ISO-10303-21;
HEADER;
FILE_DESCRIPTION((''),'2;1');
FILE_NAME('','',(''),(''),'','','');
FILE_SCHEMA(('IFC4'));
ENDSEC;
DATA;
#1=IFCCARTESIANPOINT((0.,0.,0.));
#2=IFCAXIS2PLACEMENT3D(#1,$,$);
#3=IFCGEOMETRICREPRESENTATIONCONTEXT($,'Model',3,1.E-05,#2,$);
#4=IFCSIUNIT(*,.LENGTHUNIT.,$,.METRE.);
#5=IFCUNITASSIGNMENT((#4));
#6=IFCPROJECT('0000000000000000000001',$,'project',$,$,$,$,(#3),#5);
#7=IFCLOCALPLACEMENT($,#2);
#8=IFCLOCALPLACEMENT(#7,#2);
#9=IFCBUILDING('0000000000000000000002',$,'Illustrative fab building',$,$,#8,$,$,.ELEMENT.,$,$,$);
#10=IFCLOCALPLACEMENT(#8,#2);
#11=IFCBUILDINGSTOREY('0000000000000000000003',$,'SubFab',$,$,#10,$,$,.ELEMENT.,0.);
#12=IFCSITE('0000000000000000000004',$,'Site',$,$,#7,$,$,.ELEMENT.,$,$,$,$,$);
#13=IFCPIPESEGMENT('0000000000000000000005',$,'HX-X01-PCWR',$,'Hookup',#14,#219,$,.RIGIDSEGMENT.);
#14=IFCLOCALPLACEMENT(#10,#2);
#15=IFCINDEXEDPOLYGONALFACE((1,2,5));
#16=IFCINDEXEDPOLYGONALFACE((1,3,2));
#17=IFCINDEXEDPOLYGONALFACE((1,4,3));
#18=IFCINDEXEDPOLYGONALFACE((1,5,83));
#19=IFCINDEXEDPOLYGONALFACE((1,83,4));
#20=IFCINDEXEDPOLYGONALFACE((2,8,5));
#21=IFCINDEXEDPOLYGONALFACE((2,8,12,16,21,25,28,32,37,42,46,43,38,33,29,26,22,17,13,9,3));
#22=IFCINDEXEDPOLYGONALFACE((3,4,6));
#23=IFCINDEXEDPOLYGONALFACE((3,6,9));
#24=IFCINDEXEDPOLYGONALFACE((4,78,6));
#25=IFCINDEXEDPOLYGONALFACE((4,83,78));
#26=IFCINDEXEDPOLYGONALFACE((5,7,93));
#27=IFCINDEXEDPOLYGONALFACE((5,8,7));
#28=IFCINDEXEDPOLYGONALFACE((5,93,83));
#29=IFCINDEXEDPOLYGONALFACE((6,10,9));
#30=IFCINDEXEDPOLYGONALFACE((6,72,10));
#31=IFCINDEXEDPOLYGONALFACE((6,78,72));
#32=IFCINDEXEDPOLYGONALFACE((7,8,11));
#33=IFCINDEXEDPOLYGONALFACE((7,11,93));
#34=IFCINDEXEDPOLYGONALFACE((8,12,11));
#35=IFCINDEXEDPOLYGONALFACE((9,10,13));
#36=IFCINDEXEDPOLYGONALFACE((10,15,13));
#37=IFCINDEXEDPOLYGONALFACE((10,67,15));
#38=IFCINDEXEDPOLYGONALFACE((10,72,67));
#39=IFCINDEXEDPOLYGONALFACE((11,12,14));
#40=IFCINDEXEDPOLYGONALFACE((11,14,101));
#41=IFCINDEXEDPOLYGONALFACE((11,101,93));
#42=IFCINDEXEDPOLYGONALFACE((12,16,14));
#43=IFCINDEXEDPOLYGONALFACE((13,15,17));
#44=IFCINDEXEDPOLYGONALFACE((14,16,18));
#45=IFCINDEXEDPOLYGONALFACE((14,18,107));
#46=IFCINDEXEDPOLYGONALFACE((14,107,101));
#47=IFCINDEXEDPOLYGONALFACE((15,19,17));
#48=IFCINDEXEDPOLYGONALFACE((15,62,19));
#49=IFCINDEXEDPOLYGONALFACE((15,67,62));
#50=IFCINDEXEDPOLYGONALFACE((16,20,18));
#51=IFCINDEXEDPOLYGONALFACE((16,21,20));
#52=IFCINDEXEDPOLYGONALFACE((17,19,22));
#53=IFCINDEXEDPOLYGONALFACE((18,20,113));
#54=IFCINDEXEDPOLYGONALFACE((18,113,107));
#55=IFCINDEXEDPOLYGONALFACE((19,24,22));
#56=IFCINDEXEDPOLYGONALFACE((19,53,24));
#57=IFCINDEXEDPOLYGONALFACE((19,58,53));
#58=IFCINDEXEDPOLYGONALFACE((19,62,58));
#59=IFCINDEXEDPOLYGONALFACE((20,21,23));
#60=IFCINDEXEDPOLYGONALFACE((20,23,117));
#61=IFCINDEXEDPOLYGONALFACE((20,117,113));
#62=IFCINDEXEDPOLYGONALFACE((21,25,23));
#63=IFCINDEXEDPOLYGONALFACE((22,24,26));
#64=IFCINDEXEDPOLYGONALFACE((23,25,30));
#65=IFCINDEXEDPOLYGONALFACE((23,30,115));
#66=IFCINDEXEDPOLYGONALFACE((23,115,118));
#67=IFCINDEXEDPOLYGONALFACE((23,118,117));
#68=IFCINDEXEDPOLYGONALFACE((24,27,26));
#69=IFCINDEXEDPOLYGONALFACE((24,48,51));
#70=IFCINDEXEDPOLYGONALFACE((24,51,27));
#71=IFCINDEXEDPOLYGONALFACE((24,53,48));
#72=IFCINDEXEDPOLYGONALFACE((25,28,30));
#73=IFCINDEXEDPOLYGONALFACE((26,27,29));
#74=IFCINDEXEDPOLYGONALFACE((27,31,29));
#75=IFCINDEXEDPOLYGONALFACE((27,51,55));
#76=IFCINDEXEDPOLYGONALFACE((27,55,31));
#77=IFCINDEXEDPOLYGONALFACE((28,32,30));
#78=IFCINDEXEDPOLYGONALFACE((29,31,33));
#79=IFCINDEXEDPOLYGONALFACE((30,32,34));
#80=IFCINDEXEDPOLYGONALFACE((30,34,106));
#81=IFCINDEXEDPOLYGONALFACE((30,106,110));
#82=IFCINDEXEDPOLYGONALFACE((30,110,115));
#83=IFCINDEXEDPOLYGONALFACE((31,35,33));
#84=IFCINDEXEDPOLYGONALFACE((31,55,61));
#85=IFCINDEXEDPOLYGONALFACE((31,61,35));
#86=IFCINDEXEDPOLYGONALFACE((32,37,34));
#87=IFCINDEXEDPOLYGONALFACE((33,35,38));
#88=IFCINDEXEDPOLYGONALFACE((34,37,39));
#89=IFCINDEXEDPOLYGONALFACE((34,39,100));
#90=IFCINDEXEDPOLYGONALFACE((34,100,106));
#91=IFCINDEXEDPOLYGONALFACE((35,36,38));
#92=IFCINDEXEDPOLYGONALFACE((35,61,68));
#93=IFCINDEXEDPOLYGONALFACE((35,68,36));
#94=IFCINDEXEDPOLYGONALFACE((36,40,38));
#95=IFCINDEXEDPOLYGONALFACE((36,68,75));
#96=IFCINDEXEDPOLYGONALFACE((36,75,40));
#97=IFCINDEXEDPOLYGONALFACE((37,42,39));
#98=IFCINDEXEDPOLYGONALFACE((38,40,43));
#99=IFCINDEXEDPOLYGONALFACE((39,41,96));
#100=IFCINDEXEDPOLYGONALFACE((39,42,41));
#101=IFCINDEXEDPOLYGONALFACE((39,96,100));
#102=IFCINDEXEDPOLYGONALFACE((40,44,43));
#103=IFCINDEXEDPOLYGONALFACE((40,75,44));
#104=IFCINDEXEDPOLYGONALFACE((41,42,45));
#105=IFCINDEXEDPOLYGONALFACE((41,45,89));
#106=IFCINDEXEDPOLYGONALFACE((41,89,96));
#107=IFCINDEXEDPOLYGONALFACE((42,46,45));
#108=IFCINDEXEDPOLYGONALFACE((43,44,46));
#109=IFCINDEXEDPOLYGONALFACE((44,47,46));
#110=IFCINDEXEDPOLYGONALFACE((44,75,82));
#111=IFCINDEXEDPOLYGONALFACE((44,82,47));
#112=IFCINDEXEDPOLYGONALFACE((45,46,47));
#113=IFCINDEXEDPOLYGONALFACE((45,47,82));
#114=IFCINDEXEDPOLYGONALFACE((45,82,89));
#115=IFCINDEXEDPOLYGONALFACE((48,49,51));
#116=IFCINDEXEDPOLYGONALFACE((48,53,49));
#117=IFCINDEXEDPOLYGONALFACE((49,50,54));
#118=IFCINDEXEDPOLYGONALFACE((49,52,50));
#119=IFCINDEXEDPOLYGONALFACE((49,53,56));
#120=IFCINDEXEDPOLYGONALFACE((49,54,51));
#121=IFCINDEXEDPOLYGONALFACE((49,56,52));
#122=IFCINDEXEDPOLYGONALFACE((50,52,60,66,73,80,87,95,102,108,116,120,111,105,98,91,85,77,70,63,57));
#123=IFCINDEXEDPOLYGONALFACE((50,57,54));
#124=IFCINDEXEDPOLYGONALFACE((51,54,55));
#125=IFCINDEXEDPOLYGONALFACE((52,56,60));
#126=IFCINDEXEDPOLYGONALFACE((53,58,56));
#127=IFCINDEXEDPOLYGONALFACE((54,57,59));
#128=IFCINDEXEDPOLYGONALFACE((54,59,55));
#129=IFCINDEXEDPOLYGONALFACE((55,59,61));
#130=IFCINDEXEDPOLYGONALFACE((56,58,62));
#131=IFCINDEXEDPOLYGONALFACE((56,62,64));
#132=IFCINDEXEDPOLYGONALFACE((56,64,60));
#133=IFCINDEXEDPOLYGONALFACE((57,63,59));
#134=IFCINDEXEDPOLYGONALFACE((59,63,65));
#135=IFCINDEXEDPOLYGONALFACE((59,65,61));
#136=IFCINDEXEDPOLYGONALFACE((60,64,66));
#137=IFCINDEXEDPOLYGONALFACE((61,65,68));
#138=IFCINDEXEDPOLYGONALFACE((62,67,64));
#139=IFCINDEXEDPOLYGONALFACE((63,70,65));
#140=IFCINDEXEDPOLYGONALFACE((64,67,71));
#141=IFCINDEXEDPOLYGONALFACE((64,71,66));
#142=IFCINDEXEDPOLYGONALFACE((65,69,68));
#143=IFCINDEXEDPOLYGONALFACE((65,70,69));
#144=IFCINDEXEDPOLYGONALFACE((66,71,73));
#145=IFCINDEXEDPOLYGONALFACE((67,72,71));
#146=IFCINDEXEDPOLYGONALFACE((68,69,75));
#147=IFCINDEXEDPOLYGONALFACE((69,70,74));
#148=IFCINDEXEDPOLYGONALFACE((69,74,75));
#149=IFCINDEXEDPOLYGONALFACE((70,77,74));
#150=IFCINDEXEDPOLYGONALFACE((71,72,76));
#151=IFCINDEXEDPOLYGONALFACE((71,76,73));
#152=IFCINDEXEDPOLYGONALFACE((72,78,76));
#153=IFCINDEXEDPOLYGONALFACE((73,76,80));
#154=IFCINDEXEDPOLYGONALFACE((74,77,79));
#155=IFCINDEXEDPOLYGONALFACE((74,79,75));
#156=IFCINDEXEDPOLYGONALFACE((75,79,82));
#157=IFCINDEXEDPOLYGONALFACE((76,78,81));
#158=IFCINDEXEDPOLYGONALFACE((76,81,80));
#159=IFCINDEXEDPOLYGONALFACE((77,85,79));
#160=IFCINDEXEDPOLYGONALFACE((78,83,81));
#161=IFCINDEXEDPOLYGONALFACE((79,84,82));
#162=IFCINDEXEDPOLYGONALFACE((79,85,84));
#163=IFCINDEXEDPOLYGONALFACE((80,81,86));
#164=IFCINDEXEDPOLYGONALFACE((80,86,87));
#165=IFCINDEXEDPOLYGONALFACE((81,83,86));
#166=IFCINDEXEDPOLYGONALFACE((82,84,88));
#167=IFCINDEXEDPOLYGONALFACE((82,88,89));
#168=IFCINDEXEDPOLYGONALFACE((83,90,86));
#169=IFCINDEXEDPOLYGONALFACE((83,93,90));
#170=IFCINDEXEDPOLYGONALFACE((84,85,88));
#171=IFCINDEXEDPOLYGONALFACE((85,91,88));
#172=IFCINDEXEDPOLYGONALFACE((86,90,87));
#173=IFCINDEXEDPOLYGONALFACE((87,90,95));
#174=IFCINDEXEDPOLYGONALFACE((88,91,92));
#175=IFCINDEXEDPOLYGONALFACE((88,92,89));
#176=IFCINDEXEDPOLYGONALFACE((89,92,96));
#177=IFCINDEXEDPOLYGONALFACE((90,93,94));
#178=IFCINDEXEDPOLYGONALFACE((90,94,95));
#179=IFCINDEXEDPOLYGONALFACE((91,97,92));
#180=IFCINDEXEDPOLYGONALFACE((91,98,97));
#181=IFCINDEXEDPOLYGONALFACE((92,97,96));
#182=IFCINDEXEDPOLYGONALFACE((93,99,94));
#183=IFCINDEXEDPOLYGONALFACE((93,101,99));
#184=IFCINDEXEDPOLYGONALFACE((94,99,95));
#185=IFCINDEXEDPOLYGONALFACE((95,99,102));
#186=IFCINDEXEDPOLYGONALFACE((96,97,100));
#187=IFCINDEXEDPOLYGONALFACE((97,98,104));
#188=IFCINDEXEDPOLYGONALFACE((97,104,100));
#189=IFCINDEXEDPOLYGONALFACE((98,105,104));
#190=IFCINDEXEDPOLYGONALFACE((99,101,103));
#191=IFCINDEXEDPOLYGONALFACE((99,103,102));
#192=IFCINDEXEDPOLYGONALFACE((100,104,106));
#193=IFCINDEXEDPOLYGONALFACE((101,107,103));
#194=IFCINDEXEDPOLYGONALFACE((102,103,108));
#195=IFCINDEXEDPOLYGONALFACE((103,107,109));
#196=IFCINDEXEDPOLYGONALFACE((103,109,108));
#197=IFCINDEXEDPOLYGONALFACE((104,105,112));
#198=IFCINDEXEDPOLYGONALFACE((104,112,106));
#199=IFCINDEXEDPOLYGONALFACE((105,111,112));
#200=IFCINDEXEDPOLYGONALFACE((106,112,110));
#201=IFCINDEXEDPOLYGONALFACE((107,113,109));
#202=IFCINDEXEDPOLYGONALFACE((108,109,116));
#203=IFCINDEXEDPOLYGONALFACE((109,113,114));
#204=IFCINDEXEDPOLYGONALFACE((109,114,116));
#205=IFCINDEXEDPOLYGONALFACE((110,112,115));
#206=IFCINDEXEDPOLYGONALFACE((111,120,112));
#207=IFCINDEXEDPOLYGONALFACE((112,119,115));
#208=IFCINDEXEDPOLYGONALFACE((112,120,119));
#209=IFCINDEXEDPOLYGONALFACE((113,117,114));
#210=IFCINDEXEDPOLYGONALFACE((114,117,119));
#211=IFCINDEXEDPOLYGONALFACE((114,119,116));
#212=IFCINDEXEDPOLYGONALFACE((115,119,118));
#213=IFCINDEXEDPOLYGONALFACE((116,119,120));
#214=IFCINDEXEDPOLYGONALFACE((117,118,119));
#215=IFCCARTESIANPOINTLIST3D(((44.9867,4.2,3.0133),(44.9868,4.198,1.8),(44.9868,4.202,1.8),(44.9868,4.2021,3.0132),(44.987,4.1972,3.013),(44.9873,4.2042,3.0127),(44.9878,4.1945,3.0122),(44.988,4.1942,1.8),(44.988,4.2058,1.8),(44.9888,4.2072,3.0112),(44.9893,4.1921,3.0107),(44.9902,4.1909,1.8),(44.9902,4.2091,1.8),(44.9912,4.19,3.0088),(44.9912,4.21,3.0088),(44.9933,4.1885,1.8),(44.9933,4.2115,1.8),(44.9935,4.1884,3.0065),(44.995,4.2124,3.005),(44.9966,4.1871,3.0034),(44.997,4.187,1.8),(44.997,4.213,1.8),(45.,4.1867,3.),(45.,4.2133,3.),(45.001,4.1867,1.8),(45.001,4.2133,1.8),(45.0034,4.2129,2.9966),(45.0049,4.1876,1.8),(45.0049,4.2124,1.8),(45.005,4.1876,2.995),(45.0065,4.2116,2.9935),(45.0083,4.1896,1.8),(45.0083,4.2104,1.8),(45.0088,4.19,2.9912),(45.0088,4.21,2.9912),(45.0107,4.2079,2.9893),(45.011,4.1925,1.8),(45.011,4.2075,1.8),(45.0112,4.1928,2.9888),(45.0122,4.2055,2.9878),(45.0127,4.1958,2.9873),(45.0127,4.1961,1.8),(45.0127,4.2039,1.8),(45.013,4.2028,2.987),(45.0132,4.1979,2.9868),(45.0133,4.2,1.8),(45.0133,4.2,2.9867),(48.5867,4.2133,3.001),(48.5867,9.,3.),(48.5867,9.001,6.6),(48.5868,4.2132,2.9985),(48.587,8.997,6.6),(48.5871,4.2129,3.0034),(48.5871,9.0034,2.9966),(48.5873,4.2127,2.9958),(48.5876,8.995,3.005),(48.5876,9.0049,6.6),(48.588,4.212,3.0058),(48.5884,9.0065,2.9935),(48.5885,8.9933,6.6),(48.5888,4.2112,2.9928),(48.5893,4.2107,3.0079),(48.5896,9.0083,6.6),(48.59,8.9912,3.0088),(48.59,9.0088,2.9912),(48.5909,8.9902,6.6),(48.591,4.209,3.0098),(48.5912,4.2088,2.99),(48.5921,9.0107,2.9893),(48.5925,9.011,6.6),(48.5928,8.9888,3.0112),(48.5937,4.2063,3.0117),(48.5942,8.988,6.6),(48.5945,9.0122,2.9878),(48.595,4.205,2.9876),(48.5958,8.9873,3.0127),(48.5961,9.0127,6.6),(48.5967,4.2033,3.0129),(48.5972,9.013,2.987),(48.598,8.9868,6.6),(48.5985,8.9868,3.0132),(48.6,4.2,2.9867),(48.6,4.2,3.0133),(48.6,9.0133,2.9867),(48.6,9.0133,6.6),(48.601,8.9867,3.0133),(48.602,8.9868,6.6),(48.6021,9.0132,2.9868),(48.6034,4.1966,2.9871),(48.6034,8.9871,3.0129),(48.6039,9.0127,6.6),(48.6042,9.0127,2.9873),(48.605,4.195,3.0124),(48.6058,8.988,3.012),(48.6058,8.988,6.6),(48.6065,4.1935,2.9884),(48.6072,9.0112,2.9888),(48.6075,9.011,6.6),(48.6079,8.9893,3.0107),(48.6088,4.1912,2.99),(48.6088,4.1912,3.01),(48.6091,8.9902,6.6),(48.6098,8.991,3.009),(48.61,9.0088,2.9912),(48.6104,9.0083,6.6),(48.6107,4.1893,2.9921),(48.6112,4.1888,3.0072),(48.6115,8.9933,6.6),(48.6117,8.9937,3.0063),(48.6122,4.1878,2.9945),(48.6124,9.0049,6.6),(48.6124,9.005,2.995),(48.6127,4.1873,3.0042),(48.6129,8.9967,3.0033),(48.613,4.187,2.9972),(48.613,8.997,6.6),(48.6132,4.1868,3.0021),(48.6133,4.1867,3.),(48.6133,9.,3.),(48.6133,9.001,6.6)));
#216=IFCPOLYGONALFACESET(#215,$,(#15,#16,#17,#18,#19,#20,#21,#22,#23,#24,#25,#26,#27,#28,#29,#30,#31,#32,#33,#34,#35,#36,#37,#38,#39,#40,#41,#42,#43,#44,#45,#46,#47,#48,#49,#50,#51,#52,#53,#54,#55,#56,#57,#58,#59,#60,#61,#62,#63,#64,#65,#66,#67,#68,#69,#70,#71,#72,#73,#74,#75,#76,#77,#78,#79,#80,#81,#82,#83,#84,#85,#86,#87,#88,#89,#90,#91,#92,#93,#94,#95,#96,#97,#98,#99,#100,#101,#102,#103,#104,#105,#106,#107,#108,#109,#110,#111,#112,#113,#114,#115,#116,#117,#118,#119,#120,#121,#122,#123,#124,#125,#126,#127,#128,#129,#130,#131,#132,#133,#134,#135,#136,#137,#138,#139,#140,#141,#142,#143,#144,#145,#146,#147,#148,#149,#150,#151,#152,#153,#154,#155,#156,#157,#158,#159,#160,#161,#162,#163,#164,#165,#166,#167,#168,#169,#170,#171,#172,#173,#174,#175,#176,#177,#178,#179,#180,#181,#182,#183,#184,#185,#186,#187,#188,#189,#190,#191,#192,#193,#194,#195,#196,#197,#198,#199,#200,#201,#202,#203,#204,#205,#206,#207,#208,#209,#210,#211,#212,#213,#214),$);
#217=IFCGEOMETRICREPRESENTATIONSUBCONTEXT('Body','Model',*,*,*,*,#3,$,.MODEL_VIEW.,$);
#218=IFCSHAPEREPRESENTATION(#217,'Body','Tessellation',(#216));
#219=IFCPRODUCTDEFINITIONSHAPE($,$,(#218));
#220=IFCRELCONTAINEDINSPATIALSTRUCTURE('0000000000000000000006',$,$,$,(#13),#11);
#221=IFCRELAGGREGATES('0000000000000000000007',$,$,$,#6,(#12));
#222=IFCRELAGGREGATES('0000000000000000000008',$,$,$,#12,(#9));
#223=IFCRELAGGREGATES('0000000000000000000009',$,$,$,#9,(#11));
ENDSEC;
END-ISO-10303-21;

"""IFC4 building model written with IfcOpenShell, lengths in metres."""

from ifc_helpers import new_model, entity, si_unit, origin, place, context, subcontext, project, spatial, element, save


model = new_model("IFC4")

# Units and contexts
model_context = context("Model", 3, precision=1e-05, world=origin())
body_context = subcontext(model_context, "Body", "Model", "MODEL_VIEW")
ifc_project = project(units=[si_unit("LENGTHUNIT", "METRE")], contexts=[model_context])

# Site, building, storey
site_placement = place(None, origin())
site = spatial("IfcSite", under=ifc_project, at=site_placement, Name="Site", CompositionType="ELEMENT")
building_placement = place(site_placement, origin())
building = spatial("IfcBuilding", under=site, at=building_placement, Name="Illustrative fab building", CompositionType="ELEMENT")
storey_placement = place(building_placement, origin())
storey = spatial("IfcBuildingStorey", under=building, at=storey_placement, Name="SubFab", CompositionType="ELEMENT", Elevation=0.0)

# Pipe segment
pipe_segment_1_placement = place(storey_placement, origin())
element("IfcPipeSegment", 1, at=pipe_segment_1_placement, inside=storey, Name="HX-X01-PCWR", ObjectType="Hookup", PredefinedType="RIGIDSEGMENT", context=body_context, shape_type="AdvancedSweptSolid", body=[
    entity("IfcSweptDiskSolid", entity("IfcPolyline", [entity("IfcCartesianPoint", [45.0, 4.2, 1.8]), entity("IfcCartesianPoint", [45.0, 4.2, 3.0]), entity("IfcCartesianPoint", [48.6, 4.2, 3.0]), entity("IfcCartesianPoint", [48.6, 9.0, 3.0]), entity("IfcCartesianPoint", [48.6, 9.0, 6.6])]), 0.0133),
])

save(model, "model.ifc")
